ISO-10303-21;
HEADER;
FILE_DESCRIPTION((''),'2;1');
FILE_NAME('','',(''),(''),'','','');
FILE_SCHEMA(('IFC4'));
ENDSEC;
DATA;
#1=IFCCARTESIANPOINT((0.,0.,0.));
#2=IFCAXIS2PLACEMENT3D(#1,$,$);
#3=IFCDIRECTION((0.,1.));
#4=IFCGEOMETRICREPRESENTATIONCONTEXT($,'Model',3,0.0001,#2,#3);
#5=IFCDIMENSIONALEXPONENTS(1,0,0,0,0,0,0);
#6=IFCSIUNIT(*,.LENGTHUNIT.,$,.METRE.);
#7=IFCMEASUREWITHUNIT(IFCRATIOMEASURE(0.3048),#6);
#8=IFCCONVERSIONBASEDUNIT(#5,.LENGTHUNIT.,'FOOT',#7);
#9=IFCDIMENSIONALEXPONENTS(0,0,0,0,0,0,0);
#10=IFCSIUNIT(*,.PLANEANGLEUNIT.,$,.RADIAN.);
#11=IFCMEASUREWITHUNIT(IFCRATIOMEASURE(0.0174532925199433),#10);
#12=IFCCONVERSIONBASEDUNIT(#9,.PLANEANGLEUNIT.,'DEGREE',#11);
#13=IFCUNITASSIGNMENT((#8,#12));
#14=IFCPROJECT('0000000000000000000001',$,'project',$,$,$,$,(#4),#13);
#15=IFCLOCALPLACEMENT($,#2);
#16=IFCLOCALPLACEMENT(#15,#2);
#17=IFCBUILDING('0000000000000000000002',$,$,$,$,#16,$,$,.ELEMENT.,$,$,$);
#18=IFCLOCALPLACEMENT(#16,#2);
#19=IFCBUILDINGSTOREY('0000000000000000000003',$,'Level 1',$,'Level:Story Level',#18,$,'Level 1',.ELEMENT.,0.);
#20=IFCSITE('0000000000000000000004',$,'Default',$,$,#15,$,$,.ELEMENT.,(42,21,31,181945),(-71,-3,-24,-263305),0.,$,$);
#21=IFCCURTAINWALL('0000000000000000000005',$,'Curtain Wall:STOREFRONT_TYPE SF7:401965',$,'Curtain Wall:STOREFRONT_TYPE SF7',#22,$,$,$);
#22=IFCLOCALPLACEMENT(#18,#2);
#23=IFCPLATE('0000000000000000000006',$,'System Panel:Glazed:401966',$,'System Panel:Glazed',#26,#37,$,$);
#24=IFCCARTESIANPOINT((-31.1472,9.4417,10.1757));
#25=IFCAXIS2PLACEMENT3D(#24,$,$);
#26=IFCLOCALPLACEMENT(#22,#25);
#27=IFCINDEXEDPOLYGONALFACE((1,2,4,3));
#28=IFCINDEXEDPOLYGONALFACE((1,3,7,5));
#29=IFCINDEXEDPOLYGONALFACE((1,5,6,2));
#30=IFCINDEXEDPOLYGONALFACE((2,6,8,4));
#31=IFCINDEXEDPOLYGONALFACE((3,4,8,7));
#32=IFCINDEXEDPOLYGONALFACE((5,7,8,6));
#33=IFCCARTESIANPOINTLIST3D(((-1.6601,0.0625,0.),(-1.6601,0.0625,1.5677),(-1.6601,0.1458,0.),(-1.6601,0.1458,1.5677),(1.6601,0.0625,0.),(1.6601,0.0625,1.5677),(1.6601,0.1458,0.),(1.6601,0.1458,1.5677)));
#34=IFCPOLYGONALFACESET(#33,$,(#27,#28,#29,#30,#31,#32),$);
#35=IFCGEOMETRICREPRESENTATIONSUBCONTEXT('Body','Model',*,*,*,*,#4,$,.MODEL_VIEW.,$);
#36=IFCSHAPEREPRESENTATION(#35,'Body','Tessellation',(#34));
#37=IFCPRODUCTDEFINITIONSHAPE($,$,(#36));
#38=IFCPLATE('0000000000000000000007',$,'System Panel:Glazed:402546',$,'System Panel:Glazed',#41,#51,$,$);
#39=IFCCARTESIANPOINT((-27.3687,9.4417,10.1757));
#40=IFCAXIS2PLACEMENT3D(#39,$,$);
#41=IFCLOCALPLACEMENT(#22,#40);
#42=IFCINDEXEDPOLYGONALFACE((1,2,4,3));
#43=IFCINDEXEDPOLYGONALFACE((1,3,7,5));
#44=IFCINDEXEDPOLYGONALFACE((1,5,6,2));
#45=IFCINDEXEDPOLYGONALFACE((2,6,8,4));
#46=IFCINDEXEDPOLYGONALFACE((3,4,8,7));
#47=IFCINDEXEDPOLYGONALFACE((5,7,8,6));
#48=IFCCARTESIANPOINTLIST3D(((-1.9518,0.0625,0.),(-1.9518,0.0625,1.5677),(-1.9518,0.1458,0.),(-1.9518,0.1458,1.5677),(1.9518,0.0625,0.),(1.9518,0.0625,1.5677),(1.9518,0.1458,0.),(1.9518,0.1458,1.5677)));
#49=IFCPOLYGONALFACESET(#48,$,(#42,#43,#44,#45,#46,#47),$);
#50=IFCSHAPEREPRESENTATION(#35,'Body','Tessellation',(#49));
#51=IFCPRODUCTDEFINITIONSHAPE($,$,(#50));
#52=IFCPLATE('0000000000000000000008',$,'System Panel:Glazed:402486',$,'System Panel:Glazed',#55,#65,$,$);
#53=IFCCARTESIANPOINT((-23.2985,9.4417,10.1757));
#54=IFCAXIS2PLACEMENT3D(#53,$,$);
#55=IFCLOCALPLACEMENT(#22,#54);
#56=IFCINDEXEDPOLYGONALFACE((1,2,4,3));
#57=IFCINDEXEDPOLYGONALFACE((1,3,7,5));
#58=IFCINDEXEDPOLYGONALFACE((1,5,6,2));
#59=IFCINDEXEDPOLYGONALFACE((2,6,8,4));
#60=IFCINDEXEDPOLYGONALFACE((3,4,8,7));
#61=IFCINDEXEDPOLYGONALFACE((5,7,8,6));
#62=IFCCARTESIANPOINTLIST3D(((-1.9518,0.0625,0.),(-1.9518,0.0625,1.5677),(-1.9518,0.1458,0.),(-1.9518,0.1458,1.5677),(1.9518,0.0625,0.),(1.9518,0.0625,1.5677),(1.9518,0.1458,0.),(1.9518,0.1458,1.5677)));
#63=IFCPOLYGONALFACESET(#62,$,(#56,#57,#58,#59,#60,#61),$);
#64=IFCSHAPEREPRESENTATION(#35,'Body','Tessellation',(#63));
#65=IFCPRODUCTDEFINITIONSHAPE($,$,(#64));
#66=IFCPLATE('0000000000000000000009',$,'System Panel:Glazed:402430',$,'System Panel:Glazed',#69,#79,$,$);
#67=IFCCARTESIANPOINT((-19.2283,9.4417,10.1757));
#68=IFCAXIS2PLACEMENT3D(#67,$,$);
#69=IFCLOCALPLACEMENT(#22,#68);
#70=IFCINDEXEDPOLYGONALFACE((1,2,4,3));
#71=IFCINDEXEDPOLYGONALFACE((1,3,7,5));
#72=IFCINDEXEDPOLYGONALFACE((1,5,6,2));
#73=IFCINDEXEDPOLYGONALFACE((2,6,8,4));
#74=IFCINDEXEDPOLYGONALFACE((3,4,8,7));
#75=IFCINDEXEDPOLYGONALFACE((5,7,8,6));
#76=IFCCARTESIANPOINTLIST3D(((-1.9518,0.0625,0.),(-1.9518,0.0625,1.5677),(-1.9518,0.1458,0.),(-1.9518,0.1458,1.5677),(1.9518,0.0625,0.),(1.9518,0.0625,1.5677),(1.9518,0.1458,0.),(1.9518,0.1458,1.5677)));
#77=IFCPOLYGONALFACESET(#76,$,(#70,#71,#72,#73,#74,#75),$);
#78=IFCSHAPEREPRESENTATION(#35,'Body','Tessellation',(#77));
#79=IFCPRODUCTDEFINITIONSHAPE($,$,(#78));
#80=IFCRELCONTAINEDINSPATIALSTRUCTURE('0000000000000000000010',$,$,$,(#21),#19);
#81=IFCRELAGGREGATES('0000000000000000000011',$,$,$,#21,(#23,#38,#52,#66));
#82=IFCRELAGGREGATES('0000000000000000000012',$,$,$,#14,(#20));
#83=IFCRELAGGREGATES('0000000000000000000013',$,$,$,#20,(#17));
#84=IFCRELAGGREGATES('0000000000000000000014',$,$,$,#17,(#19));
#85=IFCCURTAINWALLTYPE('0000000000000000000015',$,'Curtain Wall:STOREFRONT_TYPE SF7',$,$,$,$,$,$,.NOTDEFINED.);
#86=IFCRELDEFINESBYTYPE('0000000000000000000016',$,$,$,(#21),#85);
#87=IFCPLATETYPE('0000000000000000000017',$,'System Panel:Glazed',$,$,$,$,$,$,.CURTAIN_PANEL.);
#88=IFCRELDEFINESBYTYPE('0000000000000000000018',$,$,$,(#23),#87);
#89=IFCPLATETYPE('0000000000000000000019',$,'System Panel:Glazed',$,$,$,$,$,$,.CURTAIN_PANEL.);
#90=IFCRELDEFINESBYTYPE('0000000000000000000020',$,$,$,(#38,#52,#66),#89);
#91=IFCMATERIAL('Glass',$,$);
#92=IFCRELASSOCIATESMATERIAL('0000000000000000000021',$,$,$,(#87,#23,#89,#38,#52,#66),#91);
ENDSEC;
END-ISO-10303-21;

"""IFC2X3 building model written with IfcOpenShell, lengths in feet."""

from ifc_helpers import new_model, entity, si_unit, converted_unit, direction, frame, frame_2d, origin, place, context, subcontext, project, spatial, rectangle, extrude, source, transform, mapped, material, type_object, type_shapes, element, aggregate, save


model = new_model("IFC2X3")

# Units and contexts
model_context = context("Model", 3, precision=0.0001, world=origin(), true_north=direction((0.0, 1.0)))
body_context = subcontext(model_context, "Body", "Model", "MODEL_VIEW")
ifc_project = project(units=[converted_unit("LENGTHUNIT", "FOOT", entity("IfcRatioMeasure", 0.3048), si_unit("LENGTHUNIT", "METRE"), dimensions=[1, 0, 0, 0, 0, 0, 0]), converted_unit("PLANEANGLEUNIT", "DEGREE", entity("IfcRatioMeasure", 0.0174532925199433), si_unit("PLANEANGLEUNIT", "RADIAN"), dimensions=[0, 0, 0, 0, 0, 0, 0])], contexts=[model_context])

# Site, building, storey
site_placement = place(None, origin())
site = spatial("IfcSite", under=ifc_project, at=site_placement, Name="Default", CompositionType="ELEMENT", RefLatitude=(42, 21, 31, 181945), RefLongitude=(-71, -3, -24, -263305), RefElevation=0.0)
building_placement = place(site_placement, origin())
building = spatial("IfcBuilding", under=site, at=building_placement, CompositionType="ELEMENT")
storey_placement = place(building_placement, origin())
storey = spatial("IfcBuildingStorey", under=building, at=storey_placement, Name="Level 1", ObjectType="Level:Story Level", LongName="Level 1", CompositionType="ELEMENT", Elevation=0.0)

# Curtain wall, plates
curtain_wall_type = type_object("IfcCurtainWallType", Name="Curtain Wall:STOREFRONT_TYPE SF7", PredefinedType="NOTDEFINED")
curtain_wall_placement = place(storey_placement, origin())
curtain_wall = element("IfcCurtainWall", 1, at=curtain_wall_placement, inside=storey, type_object=curtain_wall_type, Name="Curtain Wall:STOREFRONT_TYPE SF7:401965", ObjectType="Curtain Wall:STOREFRONT_TYPE SF7")
ifc_material_1 = material(Name="Glass")
plate_type_1 = type_object("IfcPlateType", Name="System Panel:Glazed", PredefinedType="CURTAIN_PANEL", material=ifc_material_1)
shared_shape_1 = source(origin(), body_context, "Body", "SweptSolid", [
    extrude(rectangle(XDim=0.0833, YDim=3.3202, at=frame_2d((0.0, 0.0), x_axis=(1.0, 0.0))), frame((0.0, 0.1042, 0.0), z_axis=(0.0, 0.0, 1.0), x_axis=(0.0, 1.0, 0.0)), (0.0, 0.0, 1.0), 1.5677),
])
type_shapes(plate_type_1, [shared_shape_1])
plate_1_placement = place(curtain_wall_placement, frame((-31.1472, 9.4417, 10.1757)))
plate_1 = element("IfcPlate", 2, at=plate_1_placement, type_object=plate_type_1, material=ifc_material_1, Name="System Panel:Glazed:401966", ObjectType="System Panel:Glazed", context=body_context, shape_type="MappedRepresentation", body=[
    mapped(shared_shape_1, transform((0.0, 0.0, 0.0), scale=1.0)),
])
plate_type_2 = type_object("IfcPlateType", Name="System Panel:Glazed", PredefinedType="CURTAIN_PANEL", material=ifc_material_1)
shared_shape_2 = source(origin(), body_context, "Body", "SweptSolid", [
    extrude(rectangle(XDim=0.0833, YDim=3.9035, at=frame_2d((0.0, 0.0), x_axis=(1.0, 0.0))), frame((0.0, 0.1042, 0.0), z_axis=(0.0, 0.0, 1.0), x_axis=(0.0, 1.0, 0.0)), (0.0, 0.0, 1.0), 1.5677),
])
type_shapes(plate_type_2, [shared_shape_2])
plate_2_placement = place(curtain_wall_placement, frame((-27.3687, 9.4417, 10.1757)))
plate_2 = element("IfcPlate", 3, at=plate_2_placement, type_object=plate_type_2, material=ifc_material_1, Name="System Panel:Glazed:402546", ObjectType="System Panel:Glazed", context=body_context, shape_type="MappedRepresentation", body=[
    mapped(shared_shape_2, transform((0.0, 0.0, 0.0), scale=1.0)),
])
plate_3_placement = place(curtain_wall_placement, frame((-23.2985, 9.4417, 10.1757)))
plate_3 = element("IfcPlate", 4, at=plate_3_placement, type_object=plate_type_2, material=ifc_material_1, Name="System Panel:Glazed:402486", ObjectType="System Panel:Glazed", context=body_context, shape_type="MappedRepresentation", body=[
    mapped(shared_shape_2, transform((0.0, 0.0, 0.0), scale=1.0)),
])
plate_4_placement = place(curtain_wall_placement, frame((-19.2283, 9.4417, 10.1757)))
plate_4 = element("IfcPlate", 5, at=plate_4_placement, type_object=plate_type_2, material=ifc_material_1, Name="System Panel:Glazed:402430", ObjectType="System Panel:Glazed", context=body_context, shape_type="MappedRepresentation", body=[
    mapped(shared_shape_2, transform((0.0, 0.0, 0.0), scale=1.0)),
])
aggregate(curtain_wall, [plate_1, plate_2, plate_3, plate_4])

save(model, "model.ifc")
